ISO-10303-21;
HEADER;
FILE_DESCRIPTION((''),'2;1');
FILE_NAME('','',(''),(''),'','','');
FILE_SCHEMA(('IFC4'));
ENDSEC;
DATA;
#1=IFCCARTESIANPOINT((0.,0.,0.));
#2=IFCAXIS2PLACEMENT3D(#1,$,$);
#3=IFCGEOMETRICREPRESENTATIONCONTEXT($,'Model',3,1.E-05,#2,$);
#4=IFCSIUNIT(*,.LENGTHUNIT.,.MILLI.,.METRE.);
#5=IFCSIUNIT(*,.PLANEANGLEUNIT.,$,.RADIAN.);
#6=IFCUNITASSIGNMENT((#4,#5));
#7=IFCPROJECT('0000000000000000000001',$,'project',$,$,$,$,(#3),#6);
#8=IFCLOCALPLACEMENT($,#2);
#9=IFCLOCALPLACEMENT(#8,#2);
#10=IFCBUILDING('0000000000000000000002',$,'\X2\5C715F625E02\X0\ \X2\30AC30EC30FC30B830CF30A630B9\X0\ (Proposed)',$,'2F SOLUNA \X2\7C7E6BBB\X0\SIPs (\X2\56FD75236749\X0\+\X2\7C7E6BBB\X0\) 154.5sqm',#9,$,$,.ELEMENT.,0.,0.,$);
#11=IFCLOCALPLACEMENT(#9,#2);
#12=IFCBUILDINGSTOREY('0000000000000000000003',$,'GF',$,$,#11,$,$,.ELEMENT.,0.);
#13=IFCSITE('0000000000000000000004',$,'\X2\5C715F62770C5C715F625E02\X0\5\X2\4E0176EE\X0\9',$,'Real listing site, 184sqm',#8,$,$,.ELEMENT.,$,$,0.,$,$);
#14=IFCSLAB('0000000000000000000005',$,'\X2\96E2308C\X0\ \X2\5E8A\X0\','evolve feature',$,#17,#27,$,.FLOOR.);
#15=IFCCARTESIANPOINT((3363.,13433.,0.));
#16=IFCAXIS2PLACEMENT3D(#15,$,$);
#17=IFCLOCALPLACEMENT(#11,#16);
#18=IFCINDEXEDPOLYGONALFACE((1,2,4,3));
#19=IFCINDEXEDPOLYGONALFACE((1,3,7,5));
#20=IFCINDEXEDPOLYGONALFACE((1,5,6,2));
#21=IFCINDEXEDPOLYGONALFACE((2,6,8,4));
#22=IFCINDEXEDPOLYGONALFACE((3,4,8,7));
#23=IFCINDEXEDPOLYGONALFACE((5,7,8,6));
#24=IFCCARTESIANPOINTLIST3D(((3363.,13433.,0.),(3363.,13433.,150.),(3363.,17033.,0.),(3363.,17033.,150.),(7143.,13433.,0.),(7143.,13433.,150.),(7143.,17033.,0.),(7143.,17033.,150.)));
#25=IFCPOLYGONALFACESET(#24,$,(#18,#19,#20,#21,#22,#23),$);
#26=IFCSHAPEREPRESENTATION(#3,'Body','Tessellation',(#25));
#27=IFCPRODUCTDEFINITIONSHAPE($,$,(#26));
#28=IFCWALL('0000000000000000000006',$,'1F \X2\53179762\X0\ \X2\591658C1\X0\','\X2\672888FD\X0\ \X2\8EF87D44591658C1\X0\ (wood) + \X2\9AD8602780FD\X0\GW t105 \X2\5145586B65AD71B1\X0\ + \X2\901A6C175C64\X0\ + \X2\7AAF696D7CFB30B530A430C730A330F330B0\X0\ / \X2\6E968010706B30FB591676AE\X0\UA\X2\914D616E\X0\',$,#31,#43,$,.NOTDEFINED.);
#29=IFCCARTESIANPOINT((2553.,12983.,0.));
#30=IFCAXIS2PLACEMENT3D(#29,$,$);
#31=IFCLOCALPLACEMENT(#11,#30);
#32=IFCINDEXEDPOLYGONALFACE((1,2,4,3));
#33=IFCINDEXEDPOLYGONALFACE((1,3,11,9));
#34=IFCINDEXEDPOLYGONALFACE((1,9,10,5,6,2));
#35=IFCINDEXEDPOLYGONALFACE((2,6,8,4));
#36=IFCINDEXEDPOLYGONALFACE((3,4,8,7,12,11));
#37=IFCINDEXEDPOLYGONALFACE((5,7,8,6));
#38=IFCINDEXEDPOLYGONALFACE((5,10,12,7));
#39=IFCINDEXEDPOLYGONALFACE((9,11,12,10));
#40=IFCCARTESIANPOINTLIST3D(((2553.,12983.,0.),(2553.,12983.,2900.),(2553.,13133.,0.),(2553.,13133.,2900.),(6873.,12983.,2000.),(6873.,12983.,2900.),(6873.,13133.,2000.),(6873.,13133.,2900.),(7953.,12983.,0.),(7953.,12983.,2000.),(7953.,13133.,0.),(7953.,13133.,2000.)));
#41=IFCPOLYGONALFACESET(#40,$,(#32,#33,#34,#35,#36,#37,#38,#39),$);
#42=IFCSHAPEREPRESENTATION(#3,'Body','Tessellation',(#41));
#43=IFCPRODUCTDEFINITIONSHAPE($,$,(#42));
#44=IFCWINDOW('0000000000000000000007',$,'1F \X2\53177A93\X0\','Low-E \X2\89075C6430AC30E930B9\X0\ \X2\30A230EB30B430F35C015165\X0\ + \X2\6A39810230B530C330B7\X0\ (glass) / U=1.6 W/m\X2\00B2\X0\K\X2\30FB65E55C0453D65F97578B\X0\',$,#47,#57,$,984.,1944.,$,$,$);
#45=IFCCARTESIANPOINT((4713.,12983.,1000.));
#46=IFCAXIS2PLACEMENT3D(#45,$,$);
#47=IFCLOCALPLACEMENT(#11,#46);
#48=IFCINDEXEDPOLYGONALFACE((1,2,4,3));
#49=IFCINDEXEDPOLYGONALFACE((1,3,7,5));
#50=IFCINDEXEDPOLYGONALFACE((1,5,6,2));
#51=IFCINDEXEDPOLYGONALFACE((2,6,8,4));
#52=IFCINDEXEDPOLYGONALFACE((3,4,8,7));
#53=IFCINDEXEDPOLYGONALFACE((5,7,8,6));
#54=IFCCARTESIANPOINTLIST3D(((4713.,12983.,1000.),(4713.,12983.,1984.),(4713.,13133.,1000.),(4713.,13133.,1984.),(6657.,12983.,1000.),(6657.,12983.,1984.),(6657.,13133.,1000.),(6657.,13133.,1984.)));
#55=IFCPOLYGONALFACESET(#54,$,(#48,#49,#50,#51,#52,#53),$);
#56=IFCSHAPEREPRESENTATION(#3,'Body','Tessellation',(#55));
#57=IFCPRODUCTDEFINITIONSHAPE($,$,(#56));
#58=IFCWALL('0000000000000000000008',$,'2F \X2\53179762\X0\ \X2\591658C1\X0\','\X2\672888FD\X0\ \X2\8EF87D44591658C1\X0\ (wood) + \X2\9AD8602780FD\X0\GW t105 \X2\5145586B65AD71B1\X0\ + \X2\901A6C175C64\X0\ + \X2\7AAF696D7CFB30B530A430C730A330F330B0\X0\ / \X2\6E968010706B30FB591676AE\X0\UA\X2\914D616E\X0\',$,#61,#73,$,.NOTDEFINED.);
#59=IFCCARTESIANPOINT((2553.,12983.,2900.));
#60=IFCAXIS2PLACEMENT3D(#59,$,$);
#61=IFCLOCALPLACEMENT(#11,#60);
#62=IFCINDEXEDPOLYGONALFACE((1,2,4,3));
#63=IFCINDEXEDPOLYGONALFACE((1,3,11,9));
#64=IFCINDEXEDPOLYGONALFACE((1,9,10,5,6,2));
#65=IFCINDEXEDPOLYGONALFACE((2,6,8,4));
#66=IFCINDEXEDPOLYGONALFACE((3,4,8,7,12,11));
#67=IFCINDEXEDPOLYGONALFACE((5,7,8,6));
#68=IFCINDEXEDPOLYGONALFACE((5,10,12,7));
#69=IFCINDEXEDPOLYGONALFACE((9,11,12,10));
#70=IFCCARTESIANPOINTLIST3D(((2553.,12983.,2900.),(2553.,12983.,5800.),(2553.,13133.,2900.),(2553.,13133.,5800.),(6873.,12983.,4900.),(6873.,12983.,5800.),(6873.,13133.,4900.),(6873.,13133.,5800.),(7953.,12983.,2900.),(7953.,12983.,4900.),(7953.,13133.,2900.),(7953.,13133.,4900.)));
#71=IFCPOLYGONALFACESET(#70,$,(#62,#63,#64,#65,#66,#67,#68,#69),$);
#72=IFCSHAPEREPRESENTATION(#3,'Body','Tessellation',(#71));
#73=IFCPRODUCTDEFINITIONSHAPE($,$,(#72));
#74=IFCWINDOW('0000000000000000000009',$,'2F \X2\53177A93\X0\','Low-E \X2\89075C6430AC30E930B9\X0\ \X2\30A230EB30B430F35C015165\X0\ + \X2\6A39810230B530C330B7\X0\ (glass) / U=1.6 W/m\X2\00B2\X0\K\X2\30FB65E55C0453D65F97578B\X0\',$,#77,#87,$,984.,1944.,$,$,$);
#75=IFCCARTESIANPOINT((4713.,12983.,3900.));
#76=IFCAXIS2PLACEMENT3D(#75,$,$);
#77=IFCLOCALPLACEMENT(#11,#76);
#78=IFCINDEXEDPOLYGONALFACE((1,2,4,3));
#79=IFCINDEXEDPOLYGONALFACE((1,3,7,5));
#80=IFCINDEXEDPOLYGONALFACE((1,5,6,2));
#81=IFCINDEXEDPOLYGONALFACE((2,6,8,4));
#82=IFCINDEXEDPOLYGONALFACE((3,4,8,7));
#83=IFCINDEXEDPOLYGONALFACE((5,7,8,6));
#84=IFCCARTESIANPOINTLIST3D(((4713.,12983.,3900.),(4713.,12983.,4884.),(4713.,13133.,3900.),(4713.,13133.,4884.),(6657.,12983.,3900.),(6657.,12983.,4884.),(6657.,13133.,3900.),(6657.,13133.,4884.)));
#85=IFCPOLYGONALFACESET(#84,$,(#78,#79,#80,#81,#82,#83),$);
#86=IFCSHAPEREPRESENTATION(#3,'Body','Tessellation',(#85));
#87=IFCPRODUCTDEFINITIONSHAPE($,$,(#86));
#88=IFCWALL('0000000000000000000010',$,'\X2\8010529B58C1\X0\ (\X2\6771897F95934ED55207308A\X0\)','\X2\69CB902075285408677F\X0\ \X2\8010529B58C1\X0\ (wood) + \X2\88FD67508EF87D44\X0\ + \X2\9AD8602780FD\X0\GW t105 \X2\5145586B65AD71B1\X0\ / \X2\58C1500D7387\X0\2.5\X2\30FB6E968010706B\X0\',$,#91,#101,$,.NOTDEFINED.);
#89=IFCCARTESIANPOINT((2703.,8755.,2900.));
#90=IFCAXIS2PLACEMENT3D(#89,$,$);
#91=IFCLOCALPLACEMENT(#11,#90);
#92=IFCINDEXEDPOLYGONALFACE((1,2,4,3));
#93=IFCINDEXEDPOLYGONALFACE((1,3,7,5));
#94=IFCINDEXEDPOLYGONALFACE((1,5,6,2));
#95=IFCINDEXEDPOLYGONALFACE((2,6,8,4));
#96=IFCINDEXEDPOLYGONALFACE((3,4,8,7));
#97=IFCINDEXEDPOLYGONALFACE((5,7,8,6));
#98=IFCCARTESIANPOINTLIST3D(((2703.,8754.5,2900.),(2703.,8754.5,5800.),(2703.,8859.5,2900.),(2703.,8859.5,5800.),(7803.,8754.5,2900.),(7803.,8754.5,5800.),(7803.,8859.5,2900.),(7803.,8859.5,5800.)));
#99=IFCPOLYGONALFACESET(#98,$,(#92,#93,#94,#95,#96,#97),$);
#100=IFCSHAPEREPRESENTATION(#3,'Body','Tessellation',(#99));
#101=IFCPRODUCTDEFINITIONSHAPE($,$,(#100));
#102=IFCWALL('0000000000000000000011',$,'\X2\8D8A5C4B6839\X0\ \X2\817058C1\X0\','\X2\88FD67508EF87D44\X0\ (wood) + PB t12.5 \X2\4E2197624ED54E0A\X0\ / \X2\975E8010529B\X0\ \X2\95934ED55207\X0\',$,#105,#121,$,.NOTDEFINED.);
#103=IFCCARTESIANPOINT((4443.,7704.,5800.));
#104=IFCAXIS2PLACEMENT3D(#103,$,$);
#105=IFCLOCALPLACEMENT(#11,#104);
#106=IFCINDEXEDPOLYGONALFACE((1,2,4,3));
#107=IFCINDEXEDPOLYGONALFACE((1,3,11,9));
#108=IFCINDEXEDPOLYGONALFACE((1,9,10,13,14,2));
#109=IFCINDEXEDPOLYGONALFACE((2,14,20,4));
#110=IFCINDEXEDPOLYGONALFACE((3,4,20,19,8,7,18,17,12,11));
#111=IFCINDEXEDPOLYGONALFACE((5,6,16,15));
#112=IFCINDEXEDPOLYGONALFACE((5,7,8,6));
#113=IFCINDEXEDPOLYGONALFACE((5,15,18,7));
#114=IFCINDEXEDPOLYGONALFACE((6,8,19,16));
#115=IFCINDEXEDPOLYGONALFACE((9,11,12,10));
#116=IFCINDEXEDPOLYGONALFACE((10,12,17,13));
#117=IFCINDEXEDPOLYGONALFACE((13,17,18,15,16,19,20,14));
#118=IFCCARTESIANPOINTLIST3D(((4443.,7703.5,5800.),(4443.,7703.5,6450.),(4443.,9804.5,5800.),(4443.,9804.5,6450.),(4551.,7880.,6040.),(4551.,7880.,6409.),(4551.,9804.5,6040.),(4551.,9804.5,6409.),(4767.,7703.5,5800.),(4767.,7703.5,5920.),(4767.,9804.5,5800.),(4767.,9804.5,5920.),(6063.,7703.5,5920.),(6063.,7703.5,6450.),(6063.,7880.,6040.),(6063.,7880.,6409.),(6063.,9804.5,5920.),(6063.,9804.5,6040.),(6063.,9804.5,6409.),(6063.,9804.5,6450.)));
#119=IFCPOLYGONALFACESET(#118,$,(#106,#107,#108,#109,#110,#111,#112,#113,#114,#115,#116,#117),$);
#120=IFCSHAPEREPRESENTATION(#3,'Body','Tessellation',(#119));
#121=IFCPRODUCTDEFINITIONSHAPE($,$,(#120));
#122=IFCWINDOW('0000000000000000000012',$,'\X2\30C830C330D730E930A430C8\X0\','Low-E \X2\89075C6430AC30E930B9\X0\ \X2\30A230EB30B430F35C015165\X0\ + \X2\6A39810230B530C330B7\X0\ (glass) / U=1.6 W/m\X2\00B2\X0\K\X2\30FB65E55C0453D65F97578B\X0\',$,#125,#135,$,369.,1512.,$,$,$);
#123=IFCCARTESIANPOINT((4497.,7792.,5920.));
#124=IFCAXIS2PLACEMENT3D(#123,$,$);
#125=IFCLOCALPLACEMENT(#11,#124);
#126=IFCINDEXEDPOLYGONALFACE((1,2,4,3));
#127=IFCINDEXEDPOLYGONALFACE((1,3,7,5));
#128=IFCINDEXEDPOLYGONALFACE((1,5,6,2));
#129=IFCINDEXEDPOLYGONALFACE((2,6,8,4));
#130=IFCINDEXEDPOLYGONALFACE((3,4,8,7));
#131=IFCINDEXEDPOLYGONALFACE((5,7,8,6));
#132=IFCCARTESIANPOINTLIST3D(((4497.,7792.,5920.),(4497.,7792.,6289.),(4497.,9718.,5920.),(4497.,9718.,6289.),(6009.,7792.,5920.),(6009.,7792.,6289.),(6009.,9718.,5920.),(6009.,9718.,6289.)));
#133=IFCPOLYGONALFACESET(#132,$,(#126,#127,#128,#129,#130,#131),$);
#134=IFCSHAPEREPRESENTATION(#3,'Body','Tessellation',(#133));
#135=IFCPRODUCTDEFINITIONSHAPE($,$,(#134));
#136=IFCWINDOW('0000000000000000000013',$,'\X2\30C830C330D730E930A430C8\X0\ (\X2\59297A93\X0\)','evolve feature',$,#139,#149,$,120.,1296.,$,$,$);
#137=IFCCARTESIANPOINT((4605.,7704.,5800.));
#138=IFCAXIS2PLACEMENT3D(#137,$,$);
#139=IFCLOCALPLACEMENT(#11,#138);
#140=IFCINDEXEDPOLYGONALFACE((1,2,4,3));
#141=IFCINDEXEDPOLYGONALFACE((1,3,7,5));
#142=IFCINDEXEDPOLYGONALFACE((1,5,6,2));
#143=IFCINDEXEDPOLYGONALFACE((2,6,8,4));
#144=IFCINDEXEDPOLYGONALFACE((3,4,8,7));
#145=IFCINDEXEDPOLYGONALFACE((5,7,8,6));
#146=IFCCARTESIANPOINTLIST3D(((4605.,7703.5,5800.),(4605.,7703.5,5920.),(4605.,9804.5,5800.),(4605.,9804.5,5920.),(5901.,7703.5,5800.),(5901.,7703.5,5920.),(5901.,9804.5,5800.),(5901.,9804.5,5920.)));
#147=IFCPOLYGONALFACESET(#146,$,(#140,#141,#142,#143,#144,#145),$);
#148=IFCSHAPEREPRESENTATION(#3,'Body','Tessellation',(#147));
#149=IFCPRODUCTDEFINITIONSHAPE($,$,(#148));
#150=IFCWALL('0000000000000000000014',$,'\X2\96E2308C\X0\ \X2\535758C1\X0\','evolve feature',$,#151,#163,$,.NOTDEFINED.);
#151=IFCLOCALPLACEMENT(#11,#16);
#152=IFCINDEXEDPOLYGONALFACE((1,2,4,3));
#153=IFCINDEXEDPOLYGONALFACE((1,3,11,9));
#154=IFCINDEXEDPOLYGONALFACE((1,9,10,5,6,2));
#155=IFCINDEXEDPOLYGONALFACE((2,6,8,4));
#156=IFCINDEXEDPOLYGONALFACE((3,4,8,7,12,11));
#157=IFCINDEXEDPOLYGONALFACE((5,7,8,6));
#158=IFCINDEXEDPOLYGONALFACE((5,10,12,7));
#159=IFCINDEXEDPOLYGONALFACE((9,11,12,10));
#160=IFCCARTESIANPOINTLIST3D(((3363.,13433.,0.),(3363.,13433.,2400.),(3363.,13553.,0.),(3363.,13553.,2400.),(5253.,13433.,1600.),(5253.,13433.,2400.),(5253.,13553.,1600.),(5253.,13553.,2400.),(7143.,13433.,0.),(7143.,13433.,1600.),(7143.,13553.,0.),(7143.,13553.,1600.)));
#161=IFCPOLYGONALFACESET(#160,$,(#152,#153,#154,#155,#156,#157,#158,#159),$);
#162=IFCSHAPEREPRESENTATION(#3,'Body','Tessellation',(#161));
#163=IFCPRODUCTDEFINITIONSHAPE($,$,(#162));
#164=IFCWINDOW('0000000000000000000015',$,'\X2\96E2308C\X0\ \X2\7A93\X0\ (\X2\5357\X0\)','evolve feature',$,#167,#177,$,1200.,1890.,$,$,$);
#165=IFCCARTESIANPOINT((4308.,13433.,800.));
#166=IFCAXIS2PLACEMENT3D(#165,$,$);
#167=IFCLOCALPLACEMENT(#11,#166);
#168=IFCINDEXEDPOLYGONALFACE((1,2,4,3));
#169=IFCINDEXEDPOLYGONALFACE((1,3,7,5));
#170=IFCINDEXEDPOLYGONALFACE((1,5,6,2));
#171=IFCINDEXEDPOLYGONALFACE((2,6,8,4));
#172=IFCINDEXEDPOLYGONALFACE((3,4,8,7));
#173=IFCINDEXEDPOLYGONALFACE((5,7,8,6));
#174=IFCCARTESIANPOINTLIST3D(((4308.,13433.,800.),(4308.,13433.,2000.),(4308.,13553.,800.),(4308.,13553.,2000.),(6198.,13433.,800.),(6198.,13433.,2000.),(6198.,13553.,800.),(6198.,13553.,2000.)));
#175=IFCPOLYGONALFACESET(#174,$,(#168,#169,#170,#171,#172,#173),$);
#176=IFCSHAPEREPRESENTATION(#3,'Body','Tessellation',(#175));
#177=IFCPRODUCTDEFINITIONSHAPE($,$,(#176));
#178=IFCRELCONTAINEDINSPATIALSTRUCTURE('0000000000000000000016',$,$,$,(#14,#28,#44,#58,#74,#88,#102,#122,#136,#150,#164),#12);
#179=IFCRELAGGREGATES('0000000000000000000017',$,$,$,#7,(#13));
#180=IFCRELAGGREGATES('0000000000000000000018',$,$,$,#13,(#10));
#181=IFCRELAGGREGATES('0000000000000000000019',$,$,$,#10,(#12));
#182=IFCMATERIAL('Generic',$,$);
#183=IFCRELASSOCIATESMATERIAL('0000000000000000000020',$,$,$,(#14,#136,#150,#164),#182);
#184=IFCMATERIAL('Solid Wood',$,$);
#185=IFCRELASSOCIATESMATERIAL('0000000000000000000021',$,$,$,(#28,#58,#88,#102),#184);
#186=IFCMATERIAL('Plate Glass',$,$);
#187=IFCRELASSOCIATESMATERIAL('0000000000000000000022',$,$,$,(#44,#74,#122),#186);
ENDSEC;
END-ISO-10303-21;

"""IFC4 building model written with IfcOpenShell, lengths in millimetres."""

from ifc_helpers import new_model, si_unit, frame, frame_2d, origin, place, context, project, spatial, rectangle, extrude, material, element, fill, save


model = new_model("IFC4")

# Units and contexts
model_context = context("Model", 3, precision=1e-05, world=origin())
ifc_project = project(units=[si_unit("LENGTHUNIT", "METRE", prefix="MILLI"), si_unit("PLANEANGLEUNIT", "RADIAN")], contexts=[model_context])

# Site, building, storey
site_placement = place(None, origin())
site = spatial("IfcSite", under=ifc_project, at=site_placement, Name="山形県山形市5丁目9", ObjectType="Real listing site, 184sqm", CompositionType="ELEMENT", RefElevation=0.0)
building_placement = place(site_placement, origin())
building = spatial("IfcBuilding", under=site, at=building_placement, Name="山形市 ガレージハウス (Proposed)", ObjectType="2F SOLUNA 籾殻SIPs (国産杉+籾殻) 154.5sqm", CompositionType="ELEMENT", ElevationOfRefHeight=0.0, ElevationOfTerrain=0.0)
storey_placement = place(building_placement, origin())
storey = spatial("IfcBuildingStorey", under=building, at=storey_placement, Name="GF", CompositionType="ELEMENT", Elevation=0.0)

# Slab
ifc_material_1 = material(Name="Generic")
slab_placement = place(storey_placement, frame((3363.0, 13433.0, 0.0)))
element("IfcSlab", 1, at=slab_placement, inside=storey, material=ifc_material_1, Name="離れ 床", Description="evolve feature", PredefinedType="FLOOR", context=model_context, shape_type="SweptSolid", body=[
    extrude(rectangle(XDim=3780.0, YDim=3600.0, at=frame_2d((1890.0, 1800.0))), frame((3363.0, 13433.0, 0.0)), (0.0, 0.0, 1.0), 150.0),
])

# Wall, opening, window
ifc_material_2 = material(Name="Solid Wood")
wall_1_placement = place(storey_placement, frame((2553.0, 12983.0, 0.0)))
wall_1 = element("IfcWall", 2, at=wall_1_placement, inside=storey, material=ifc_material_2, Name="1F 北面 外壁", Description="木製 軸組外壁 (wood) + 高性能GW t105 充填断熱 + 通気層 + 窯業系サイディング / 準耐火・外皮UA配慮", PredefinedType="NOTDEFINED", context=model_context, shape_type="SweptSolid", body=[
    extrude(rectangle(XDim=5400.0, YDim=150.0, at=frame_2d((2700.0, 75.0))), frame((2553.0, 12983.0, 0.0)), (0.0, 0.0, 1.0), 2900.0),
])
opening_1_placement = place(storey_placement, frame((4713.0, 12983.0, 1000.0)))
opening_1 = element("IfcOpeningElement", 3, at=opening_1_placement, cuts=wall_1, PredefinedType="NOTDEFINED", context=model_context, shape_type="SweptSolid", body=[
    extrude(rectangle(XDim=1944.0, YDim=150.0, at=frame_2d((972.0, 75.0))), frame((4713.0, 12983.0, 1000.0)), (0.0, 0.0, 1.0), 984.0),
])
ifc_material_3 = material(Name="Plate Glass")
window_1_placement = place(storey_placement, frame((4713.0, 12983.0, 1000.0)))
window_1 = element("IfcWindow", 4, at=window_1_placement, inside=storey, material=ifc_material_3, Name="1F 北窓", Description="Low-E 複層ガラス アルゴン封入 + 樹脂サッシ (glass) / U=1.6 W/m²K・日射取得型", OverallHeight=984.0, OverallWidth=1944.0, context=model_context, shape_type="SweptSolid", body=[
    extrude(rectangle(XDim=1944.0, YDim=150.0, at=frame_2d((972.0, 75.0))), frame((4713.0, 12983.0, 1000.0)), (0.0, 0.0, 1.0), 984.0),
])
fill(opening_1, window_1)

# Wall, opening, window
wall_2_placement = place(storey_placement, frame((2553.0, 12983.0, 2900.0)))
wall_2 = element("IfcWall", 5, at=wall_2_placement, inside=storey, material=ifc_material_2, Name="2F 北面 外壁", Description="木製 軸組外壁 (wood) + 高性能GW t105 充填断熱 + 通気層 + 窯業系サイディング / 準耐火・外皮UA配慮", PredefinedType="NOTDEFINED", context=model_context, shape_type="SweptSolid", body=[
    extrude(rectangle(XDim=5400.0, YDim=150.0, at=frame_2d((2700.0, 75.0))), frame((2553.0, 12983.0, 2900.0)), (0.0, 0.0, 1.0), 2900.0),
])
opening_2_placement = place(storey_placement, frame((4713.0, 12983.0, 3900.0)))
opening_2 = element("IfcOpeningElement", 6, at=opening_2_placement, cuts=wall_2, PredefinedType="NOTDEFINED", context=model_context, shape_type="SweptSolid", body=[
    extrude(rectangle(XDim=1944.0, YDim=150.0, at=frame_2d((972.0, 75.0))), frame((4713.0, 12983.0, 3900.0)), (0.0, 0.0, 1.0), 984.0),
])
window_2_placement = place(storey_placement, frame((4713.0, 12983.0, 3900.0)))
window_2 = element("IfcWindow", 7, at=window_2_placement, inside=storey, material=ifc_material_3, Name="2F 北窓", Description="Low-E 複層ガラス アルゴン封入 + 樹脂サッシ (glass) / U=1.6 W/m²K・日射取得型", OverallHeight=984.0, OverallWidth=1944.0, context=model_context, shape_type="SweptSolid", body=[
    extrude(rectangle(XDim=1944.0, YDim=150.0, at=frame_2d((972.0, 75.0))), frame((4713.0, 12983.0, 3900.0)), (0.0, 0.0, 1.0), 984.0),
])
fill(opening_2, window_2)

# Wall
wall_3_placement = place(storey_placement, frame((2703.0, 8755.0, 2900.0)))
element("IfcWall", 8, at=wall_3_placement, inside=storey, material=ifc_material_2, Name="耐力壁 (東西間仕切り)", Description="構造用合板 耐力壁 (wood) + 製材軸組 + 高性能GW t105 充填断熱 / 壁倍率2.5・準耐火", PredefinedType="NOTDEFINED", context=model_context, shape_type="SweptSolid", body=[
    extrude(rectangle(XDim=5100.0, YDim=105.0, at=frame_2d((2550.0, 52.0))), frame((2703.0, 8755.0, 2900.0)), (0.0, 0.0, 1.0), 2900.0),
])

# Wall, openings, windows
wall_4_placement = place(storey_placement, frame((4443.0, 7704.0, 5800.0)))
wall_4 = element("IfcWall", 9, at=wall_4_placement, inside=storey, material=ifc_material_2, Name="越屋根 腰壁", Description="製材軸組 (wood) + PB t12.5 両面仕上 / 非耐力 間仕切", PredefinedType="NOTDEFINED", context=model_context, shape_type="SweptSolid", body=[
    extrude(rectangle(XDim=1620.0, YDim=2101.0, at=frame_2d((810.0, 1050.0))), frame((4443.0, 7704.0, 5800.0)), (0.0, 0.0, 1.0), 650.0),
])
opening_3_placement = place(storey_placement, frame((4497.0, 7792.0, 5920.0)))
opening_3 = element("IfcOpeningElement", 10, at=opening_3_placement, cuts=wall_4, PredefinedType="NOTDEFINED", context=model_context, shape_type="SweptSolid", body=[
    extrude(rectangle(XDim=1512.0, YDim=1926.0, at=frame_2d((756.0, 963.0))), frame((4497.0, 7792.0, 5920.0)), (0.0, 0.0, 1.0), 369.0),
])
opening_4_placement = place(storey_placement, frame((4605.0, 7704.0, 5800.0)))
opening_4 = element("IfcOpeningElement", 11, at=opening_4_placement, cuts=wall_4, PredefinedType="NOTDEFINED", context=model_context, shape_type="SweptSolid", body=[
    extrude(rectangle(XDim=1296.0, YDim=2101.0, at=frame_2d((648.0, 1050.0))), frame((4605.0, 7704.0, 5800.0)), (0.0, 0.0, 1.0), 120.0),
])
window_3_placement = place(storey_placement, frame((4497.0, 7792.0, 5920.0)))
window_3 = element("IfcWindow", 12, at=window_3_placement, inside=storey, material=ifc_material_3, Name="トップライト", Description="Low-E 複層ガラス アルゴン封入 + 樹脂サッシ (glass) / U=1.6 W/m²K・日射取得型", OverallHeight=369.0, OverallWidth=1512.0, context=model_context, shape_type="SweptSolid", body=[
    extrude(rectangle(XDim=1512.0, YDim=1926.0, at=frame_2d((756.0, 963.0))), frame((4497.0, 7792.0, 5920.0)), (0.0, 0.0, 1.0), 369.0),
])
fill(opening_3, window_3)
window_4_placement = place(storey_placement, frame((4605.0, 7704.0, 5800.0)))
window_4 = element("IfcWindow", 13, at=window_4_placement, inside=storey, material=ifc_material_1, Name="トップライト (天窓)", Description="evolve feature", OverallHeight=120.0, OverallWidth=1296.0, context=model_context, shape_type="SweptSolid", body=[
    extrude(rectangle(XDim=1296.0, YDim=2101.0, at=frame_2d((648.0, 1050.0))), frame((4605.0, 7704.0, 5800.0)), (0.0, 0.0, 1.0), 120.0),
])
fill(opening_4, window_4)

# Wall, opening, window
wall_5_placement = place(storey_placement, frame((3363.0, 13433.0, 0.0)))
wall_5 = element("IfcWall", 14, at=wall_5_placement, inside=storey, material=ifc_material_1, Name="離れ 南壁", Description="evolve feature", PredefinedType="NOTDEFINED", context=model_context, shape_type="SweptSolid", body=[
    extrude(rectangle(XDim=3780.0, YDim=120.0, at=frame_2d((1890.0, 60.0))), frame((3363.0, 13433.0, 0.0)), (0.0, 0.0, 1.0), 2400.0),
])
opening_5_placement = place(storey_placement, frame((4308.0, 13433.0, 800.0)))
opening_5 = element("IfcOpeningElement", 15, at=opening_5_placement, cuts=wall_5, PredefinedType="NOTDEFINED", context=model_context, shape_type="SweptSolid", body=[
    extrude(rectangle(XDim=1890.0, YDim=120.0, at=frame_2d((945.0, 60.0))), frame((4308.0, 13433.0, 800.0)), (0.0, 0.0, 1.0), 1200.0),
])
window_5_placement = place(storey_placement, frame((4308.0, 13433.0, 800.0)))
window_5 = element("IfcWindow", 16, at=window_5_placement, inside=storey, material=ifc_material_1, Name="離れ 窓 (南)", Description="evolve feature", OverallHeight=1200.0, OverallWidth=1890.0, context=model_context, shape_type="SweptSolid", body=[
    extrude(rectangle(XDim=1890.0, YDim=120.0, at=frame_2d((945.0, 60.0))), frame((4308.0, 13433.0, 800.0)), (0.0, 0.0, 1.0), 1200.0),
])
fill(opening_5, window_5)

save(model, "model.ifc")
